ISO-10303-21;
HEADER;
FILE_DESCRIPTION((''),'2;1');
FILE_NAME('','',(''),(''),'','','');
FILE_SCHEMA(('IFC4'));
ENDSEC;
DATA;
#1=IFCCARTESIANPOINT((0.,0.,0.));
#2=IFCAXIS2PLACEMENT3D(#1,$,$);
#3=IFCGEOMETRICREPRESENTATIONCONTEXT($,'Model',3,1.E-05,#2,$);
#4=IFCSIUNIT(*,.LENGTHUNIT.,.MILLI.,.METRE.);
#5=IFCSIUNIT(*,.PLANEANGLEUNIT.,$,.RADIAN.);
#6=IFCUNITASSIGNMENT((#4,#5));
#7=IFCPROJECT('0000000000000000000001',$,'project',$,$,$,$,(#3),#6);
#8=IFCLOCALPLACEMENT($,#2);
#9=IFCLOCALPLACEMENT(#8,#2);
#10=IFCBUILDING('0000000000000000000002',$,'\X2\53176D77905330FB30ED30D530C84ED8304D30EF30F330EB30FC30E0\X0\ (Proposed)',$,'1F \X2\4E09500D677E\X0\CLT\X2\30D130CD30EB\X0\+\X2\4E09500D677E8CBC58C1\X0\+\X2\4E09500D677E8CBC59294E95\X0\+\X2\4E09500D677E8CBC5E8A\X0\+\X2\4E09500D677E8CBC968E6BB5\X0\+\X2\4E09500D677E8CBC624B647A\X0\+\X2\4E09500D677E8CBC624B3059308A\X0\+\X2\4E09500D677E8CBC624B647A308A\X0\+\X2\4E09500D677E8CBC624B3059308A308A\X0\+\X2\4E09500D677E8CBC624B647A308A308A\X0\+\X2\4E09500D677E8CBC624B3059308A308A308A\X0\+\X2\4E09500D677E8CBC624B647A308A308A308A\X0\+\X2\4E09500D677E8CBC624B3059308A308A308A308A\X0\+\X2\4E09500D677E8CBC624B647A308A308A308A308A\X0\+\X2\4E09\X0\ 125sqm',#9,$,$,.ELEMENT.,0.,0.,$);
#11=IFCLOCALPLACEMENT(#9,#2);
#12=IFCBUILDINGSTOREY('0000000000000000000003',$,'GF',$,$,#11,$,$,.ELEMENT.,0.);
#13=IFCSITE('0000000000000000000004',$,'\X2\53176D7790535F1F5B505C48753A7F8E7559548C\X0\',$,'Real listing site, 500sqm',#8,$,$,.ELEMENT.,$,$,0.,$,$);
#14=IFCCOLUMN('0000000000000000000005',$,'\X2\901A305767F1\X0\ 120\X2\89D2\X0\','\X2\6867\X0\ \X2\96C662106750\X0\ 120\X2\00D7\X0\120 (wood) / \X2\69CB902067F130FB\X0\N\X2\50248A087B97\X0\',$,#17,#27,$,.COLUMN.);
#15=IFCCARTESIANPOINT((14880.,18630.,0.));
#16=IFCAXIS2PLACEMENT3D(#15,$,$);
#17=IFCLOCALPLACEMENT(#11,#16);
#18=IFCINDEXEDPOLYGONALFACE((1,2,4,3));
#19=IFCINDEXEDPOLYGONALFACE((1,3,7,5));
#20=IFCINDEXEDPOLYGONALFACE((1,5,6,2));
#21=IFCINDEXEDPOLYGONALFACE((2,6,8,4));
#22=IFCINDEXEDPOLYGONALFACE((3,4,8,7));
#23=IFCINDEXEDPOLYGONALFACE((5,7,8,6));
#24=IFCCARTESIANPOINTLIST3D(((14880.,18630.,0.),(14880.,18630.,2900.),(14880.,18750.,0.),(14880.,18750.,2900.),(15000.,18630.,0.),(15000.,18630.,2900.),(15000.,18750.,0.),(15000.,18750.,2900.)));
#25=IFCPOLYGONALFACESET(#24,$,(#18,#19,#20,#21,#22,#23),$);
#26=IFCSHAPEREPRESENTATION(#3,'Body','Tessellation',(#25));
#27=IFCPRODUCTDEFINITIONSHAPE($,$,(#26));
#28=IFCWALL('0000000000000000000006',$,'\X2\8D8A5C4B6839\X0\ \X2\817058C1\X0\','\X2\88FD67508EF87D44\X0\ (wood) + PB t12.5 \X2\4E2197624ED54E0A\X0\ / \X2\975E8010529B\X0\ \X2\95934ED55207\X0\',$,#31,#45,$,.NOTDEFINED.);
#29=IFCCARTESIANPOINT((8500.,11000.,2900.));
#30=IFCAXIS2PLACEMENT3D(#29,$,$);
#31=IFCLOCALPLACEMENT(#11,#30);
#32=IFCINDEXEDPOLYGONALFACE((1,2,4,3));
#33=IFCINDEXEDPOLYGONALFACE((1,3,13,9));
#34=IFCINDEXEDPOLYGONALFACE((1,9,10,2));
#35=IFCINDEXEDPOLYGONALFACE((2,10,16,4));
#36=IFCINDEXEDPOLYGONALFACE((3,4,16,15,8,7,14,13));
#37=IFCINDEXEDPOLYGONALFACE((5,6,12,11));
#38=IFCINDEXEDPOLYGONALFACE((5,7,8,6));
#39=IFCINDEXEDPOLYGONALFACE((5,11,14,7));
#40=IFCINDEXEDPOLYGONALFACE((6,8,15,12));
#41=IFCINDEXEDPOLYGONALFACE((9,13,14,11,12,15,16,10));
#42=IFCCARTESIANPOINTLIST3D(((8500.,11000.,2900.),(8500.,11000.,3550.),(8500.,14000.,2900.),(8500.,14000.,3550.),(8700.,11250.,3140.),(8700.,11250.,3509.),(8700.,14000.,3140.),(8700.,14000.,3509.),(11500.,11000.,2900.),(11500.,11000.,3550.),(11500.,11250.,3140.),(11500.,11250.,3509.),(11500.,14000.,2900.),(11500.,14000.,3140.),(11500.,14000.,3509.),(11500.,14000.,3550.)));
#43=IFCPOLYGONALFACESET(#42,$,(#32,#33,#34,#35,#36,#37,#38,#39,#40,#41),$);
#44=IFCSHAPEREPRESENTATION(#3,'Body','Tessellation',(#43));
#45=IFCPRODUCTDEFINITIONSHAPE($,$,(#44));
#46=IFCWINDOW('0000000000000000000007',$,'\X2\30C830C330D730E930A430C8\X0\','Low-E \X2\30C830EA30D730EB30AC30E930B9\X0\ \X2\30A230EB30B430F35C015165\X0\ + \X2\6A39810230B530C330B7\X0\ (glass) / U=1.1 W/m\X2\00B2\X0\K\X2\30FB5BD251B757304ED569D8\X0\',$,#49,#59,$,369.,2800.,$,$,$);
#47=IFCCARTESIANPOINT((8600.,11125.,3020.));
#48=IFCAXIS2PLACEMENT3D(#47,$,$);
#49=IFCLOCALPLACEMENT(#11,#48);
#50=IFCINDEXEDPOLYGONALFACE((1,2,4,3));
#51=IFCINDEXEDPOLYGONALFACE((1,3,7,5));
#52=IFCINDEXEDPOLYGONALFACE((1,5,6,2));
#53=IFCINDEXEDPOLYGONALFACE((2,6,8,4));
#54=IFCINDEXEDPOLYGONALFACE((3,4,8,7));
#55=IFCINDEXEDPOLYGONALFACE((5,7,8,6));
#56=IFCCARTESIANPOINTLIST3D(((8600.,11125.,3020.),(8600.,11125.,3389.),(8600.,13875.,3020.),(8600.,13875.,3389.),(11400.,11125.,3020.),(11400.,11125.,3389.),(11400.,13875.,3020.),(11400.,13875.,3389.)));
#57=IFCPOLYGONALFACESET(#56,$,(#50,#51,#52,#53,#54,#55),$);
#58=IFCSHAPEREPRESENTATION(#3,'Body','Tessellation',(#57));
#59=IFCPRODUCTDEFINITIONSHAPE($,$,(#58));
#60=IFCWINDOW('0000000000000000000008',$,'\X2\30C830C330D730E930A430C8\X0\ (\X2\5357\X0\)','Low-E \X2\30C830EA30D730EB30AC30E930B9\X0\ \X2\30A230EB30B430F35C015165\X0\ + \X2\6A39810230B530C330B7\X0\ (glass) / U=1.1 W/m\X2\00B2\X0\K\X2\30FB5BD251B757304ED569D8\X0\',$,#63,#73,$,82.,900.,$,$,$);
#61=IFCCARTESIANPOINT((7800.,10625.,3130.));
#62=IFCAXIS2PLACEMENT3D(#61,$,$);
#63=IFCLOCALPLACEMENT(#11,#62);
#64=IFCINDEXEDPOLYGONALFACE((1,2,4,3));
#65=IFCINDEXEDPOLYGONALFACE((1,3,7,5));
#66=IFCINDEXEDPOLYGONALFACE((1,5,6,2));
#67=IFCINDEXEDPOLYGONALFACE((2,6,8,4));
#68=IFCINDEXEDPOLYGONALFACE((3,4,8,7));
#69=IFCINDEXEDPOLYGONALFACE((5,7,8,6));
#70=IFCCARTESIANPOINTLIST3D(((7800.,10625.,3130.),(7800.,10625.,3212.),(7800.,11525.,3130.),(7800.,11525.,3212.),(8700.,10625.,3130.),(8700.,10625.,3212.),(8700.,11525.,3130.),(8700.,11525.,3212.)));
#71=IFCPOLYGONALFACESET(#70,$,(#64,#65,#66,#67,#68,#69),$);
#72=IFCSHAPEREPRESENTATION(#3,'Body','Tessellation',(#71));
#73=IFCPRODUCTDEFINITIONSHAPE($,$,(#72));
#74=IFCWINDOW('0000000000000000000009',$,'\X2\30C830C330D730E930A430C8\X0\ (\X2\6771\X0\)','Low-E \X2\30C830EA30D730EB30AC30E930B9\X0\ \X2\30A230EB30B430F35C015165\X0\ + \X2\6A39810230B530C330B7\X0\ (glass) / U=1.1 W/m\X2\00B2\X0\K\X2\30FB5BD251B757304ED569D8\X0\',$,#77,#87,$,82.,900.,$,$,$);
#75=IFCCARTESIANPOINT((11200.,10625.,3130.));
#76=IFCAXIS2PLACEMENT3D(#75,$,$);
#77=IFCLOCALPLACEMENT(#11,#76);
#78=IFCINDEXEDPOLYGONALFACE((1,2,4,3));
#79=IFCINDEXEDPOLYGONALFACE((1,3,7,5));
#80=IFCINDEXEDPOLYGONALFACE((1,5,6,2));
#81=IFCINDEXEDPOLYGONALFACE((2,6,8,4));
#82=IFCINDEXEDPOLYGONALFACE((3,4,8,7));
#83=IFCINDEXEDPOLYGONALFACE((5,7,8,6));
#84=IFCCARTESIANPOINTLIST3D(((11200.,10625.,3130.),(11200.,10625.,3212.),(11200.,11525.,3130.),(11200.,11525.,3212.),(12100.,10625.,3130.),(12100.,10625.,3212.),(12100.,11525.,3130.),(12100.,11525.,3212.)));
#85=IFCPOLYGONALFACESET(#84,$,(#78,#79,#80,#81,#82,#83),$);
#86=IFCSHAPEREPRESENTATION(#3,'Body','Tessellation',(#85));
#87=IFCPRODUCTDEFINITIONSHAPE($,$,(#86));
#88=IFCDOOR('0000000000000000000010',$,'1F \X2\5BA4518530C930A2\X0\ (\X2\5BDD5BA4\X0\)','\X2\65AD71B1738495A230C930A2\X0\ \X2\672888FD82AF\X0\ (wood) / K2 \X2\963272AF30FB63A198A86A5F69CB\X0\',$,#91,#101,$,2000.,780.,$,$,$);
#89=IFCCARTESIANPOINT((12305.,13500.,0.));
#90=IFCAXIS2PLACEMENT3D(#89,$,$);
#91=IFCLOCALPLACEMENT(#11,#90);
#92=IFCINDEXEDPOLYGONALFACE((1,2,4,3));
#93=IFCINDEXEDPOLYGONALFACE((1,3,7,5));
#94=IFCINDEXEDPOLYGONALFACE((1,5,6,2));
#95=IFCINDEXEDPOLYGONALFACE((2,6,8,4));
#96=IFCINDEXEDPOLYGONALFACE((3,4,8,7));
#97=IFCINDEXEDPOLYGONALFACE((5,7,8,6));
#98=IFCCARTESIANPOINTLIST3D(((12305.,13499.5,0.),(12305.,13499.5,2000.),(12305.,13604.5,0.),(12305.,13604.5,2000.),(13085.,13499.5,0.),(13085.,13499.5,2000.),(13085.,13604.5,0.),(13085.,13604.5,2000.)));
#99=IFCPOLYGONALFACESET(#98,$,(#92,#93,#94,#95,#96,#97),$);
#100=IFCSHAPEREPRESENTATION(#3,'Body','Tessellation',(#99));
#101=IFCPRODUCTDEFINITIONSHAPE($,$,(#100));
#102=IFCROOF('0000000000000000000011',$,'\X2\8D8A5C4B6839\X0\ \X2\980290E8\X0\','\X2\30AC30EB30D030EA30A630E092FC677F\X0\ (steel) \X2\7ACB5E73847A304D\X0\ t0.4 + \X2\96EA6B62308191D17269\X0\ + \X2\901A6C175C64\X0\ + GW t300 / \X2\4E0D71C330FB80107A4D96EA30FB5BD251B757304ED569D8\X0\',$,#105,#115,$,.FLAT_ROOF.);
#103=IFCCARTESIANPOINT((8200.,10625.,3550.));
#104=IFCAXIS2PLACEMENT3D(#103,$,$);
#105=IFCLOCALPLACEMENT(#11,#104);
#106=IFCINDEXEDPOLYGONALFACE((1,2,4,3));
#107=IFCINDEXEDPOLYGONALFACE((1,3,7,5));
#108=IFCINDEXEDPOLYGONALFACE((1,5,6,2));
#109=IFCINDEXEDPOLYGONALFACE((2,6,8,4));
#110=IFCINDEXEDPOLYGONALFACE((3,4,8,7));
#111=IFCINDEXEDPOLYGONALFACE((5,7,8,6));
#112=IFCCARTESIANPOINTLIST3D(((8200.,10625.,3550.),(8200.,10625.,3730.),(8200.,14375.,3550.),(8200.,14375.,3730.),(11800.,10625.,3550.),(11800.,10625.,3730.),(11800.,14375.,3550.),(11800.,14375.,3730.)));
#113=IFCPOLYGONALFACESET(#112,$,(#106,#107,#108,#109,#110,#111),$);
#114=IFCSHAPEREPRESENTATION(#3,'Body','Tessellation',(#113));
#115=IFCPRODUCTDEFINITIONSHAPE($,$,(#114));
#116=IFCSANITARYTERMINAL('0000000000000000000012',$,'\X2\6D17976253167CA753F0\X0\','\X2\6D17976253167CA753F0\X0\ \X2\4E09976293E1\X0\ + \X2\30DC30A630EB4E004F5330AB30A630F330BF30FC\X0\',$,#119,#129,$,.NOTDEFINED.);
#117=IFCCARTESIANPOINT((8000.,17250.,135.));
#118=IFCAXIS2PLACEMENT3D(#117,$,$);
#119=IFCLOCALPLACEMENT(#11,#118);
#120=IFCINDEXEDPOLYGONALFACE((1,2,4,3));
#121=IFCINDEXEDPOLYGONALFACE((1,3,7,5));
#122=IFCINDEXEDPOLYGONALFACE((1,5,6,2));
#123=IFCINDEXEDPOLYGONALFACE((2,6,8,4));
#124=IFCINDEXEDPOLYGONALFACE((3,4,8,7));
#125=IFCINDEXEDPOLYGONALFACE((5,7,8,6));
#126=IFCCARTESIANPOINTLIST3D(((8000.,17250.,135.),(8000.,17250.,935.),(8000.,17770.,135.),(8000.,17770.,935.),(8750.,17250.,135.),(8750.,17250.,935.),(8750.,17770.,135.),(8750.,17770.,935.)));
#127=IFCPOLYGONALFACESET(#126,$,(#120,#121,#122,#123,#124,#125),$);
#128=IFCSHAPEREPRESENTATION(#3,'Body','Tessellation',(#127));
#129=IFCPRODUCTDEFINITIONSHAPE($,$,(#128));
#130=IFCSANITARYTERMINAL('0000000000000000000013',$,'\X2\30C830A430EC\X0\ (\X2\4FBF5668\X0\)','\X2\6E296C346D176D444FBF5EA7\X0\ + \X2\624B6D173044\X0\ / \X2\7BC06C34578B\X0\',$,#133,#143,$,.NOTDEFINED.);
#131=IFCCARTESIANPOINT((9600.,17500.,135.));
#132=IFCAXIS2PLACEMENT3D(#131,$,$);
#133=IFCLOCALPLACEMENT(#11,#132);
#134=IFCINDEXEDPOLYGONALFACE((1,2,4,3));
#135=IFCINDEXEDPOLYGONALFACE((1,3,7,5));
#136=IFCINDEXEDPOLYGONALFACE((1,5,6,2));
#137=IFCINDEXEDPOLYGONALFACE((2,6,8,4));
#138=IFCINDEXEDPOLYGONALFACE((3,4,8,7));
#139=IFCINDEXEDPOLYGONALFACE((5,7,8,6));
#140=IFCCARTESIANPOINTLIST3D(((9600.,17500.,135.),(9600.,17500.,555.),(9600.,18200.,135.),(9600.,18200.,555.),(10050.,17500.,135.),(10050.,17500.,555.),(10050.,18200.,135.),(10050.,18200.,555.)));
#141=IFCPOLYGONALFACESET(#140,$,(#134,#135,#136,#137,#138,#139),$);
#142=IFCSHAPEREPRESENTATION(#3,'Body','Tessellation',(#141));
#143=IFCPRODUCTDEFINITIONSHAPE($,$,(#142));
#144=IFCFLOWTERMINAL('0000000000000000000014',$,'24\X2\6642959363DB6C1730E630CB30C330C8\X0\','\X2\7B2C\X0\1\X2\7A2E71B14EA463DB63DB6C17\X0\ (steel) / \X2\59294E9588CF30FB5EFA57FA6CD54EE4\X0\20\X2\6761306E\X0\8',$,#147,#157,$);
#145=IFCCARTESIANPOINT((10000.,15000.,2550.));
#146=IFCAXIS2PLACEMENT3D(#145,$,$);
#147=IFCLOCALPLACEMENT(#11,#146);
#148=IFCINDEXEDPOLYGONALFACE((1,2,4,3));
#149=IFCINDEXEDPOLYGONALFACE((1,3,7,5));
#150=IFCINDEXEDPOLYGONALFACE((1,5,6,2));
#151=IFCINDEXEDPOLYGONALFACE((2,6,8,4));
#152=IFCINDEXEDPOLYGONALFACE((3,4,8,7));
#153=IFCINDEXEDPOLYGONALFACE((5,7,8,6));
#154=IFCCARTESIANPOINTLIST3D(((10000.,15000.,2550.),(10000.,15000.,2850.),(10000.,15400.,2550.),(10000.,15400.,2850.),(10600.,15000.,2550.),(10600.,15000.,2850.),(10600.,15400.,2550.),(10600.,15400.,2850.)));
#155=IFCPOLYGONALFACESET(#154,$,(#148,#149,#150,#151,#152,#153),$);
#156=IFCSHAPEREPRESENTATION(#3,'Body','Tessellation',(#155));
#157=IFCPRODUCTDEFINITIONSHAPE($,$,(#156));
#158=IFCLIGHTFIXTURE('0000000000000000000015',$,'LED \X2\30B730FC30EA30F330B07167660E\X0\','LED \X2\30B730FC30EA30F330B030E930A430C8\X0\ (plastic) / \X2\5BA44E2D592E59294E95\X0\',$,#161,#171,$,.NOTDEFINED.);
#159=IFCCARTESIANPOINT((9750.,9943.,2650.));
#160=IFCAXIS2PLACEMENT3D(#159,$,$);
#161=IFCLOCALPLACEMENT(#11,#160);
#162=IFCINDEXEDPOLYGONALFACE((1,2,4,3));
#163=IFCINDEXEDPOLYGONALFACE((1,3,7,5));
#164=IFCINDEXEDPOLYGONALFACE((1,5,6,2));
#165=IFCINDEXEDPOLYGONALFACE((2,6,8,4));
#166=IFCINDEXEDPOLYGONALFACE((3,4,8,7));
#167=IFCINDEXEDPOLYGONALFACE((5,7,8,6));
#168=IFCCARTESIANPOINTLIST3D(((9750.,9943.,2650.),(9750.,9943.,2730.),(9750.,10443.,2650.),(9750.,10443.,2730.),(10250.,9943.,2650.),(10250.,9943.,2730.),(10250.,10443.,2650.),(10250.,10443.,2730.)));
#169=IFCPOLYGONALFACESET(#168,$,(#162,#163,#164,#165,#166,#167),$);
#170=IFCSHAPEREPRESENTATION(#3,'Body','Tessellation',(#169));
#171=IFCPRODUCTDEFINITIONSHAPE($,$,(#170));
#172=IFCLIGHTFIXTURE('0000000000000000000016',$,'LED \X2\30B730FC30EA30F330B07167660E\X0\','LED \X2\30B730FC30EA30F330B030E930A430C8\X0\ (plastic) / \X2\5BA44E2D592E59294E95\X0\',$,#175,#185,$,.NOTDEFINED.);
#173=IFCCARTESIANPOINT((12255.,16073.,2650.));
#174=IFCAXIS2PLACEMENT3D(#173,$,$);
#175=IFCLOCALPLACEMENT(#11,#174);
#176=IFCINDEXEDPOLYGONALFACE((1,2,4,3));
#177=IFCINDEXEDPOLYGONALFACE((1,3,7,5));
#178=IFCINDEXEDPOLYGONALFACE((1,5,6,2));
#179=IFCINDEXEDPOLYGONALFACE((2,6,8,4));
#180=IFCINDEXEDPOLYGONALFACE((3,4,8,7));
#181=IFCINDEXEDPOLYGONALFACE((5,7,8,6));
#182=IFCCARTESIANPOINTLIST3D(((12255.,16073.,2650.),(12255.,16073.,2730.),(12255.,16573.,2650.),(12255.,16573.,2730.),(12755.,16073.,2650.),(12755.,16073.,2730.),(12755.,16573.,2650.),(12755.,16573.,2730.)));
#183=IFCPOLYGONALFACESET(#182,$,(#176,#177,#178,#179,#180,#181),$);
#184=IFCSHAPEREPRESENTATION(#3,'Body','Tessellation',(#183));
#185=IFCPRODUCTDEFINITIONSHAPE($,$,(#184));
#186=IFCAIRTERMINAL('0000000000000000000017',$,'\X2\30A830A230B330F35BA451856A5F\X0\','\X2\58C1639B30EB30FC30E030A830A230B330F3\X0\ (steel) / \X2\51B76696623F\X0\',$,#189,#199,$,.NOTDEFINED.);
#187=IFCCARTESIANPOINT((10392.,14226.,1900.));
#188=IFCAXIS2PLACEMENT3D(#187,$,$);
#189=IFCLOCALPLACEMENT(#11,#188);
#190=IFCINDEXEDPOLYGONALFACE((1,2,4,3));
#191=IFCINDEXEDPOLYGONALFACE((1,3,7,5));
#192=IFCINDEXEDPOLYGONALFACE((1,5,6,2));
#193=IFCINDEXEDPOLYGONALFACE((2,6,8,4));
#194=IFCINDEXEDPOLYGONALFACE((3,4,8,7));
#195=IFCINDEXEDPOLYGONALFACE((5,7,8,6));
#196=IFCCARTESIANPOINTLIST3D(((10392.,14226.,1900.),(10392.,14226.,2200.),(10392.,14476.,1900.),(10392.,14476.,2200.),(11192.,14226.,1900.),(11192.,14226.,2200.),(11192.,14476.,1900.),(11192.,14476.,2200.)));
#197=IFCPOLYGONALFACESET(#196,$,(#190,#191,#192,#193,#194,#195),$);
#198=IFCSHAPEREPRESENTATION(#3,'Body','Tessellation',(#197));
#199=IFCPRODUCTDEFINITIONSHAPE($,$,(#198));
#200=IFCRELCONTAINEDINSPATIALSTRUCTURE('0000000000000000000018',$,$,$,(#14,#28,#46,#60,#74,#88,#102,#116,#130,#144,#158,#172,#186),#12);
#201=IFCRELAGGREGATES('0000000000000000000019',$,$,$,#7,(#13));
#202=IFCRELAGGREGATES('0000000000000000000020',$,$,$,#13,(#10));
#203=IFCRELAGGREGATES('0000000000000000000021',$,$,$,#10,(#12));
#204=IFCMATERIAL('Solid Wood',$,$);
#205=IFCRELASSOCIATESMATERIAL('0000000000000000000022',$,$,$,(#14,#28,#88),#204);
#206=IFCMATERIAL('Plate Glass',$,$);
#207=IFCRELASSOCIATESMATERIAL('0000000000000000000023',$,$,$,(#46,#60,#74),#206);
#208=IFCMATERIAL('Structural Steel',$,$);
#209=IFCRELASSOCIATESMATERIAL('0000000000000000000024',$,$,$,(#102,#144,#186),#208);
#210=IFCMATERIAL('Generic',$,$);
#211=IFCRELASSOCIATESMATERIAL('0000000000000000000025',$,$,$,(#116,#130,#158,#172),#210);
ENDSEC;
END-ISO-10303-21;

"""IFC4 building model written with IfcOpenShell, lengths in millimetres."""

from ifc_helpers import new_model, si_unit, frame, frame_2d, origin, place, context, project, spatial, rectangle, extrude, material, element, fill, save


model = new_model("IFC4")

# Units and contexts
model_context = context("Model", 3, precision=1e-05, world=origin())
ifc_project = project(units=[si_unit("LENGTHUNIT", "METRE", prefix="MILLI"), si_unit("PLANEANGLEUNIT", "RADIAN")], contexts=[model_context])

# Site, building, storey
site_placement = place(None, origin())
site = spatial("IfcSite", under=ifc_project, at=site_placement, Name="北海道弟子屈町美留和", ObjectType="Real listing site, 500sqm", CompositionType="ELEMENT", RefElevation=0.0)
building_placement = place(site_placement, origin())
building = spatial("IfcBuilding", under=site, at=building_placement, Name="北海道・ロフト付きワンルーム (Proposed)", ObjectType="1F 三倍松CLTパネル+三倍松貼壁+三倍松貼天井+三倍松貼床+三倍松貼階段+三倍松貼手摺+三倍松貼手すり+三倍松貼手摺り+三倍松貼手すりり+三倍松貼手摺りり+三倍松貼手すりりり+三倍松貼手摺りりり+三倍松貼手すりりりり+三倍松貼手摺りりりり+三 125sqm", CompositionType="ELEMENT", ElevationOfRefHeight=0.0, ElevationOfTerrain=0.0)
storey_placement = place(building_placement, origin())
storey = spatial("IfcBuildingStorey", under=building, at=storey_placement, Name="GF", CompositionType="ELEMENT", Elevation=0.0)

# Column
ifc_material_1 = material(Name="Solid Wood")
column_1_placement = place(storey_placement, frame((14880.0, 18630.0, 0.0)))
element("IfcColumn", 1, at=column_1_placement, inside=storey, material=ifc_material_1, Name="通し柱 120角", Description="桧 集成材 120×120 (wood) / 構造柱・N値計算", PredefinedType="COLUMN", context=model_context, shape_type="SweptSolid", body=[
    extrude(rectangle(XDim=120.0, YDim=120.0, at=frame_2d((60.0, 60.0))), frame((14880.0, 18630.0, 0.0)), (0.0, 0.0, 1.0), 2900.0),
])

# Wall, openings, windows
wall_1_placement = place(storey_placement, frame((8500.0, 11000.0, 2900.0)))
wall_1 = element("IfcWall", 2, at=wall_1_placement, inside=storey, material=ifc_material_1, Name="越屋根 腰壁", Description="製材軸組 (wood) + PB t12.5 両面仕上 / 非耐力 間仕切", PredefinedType="NOTDEFINED", context=model_context, shape_type="SweptSolid", body=[
    extrude(rectangle(XDim=3000.0, YDim=3000.0, at=frame_2d((1500.0, 1500.0))), frame((8500.0, 11000.0, 2900.0)), (0.0, 0.0, 1.0), 650.0),
])
opening_1_placement = place(storey_placement, frame((8600.0, 11125.0, 3020.0)))
opening_1 = element("IfcOpeningElement", 3, at=opening_1_placement, cuts=wall_1, PredefinedType="NOTDEFINED", context=model_context, shape_type="SweptSolid", body=[
    extrude(rectangle(XDim=2800.0, YDim=2750.0, at=frame_2d((1400.0, 1375.0))), frame((8600.0, 11125.0, 3020.0)), (0.0, 0.0, 1.0), 369.0),
])
opening_2_placement = place(storey_placement, frame((7800.0, 10625.0, 3130.0)))
opening_2 = element("IfcOpeningElement", 4, at=opening_2_placement, cuts=wall_1, PredefinedType="NOTDEFINED", context=model_context, shape_type="SweptSolid", body=[
    extrude(rectangle(XDim=900.0, YDim=900.0, at=frame_2d((450.0, 450.0))), frame((7800.0, 10625.0, 3130.0)), (0.0, 0.0, 1.0), 82.0),
])
opening_3_placement = place(storey_placement, frame((11200.0, 10625.0, 3130.0)))
opening_3 = element("IfcOpeningElement", 5, at=opening_3_placement, cuts=wall_1, PredefinedType="NOTDEFINED", context=model_context, shape_type="SweptSolid", body=[
    extrude(rectangle(XDim=900.0, YDim=900.0, at=frame_2d((450.0, 450.0))), frame((11200.0, 10625.0, 3130.0)), (0.0, 0.0, 1.0), 82.0),
])
ifc_material_2 = material(Name="Plate Glass")
window_1_placement = place(storey_placement, frame((8600.0, 11125.0, 3020.0)))
window_1 = element("IfcWindow", 6, at=window_1_placement, inside=storey, material=ifc_material_2, Name="トップライト", Description="Low-E トリプルガラス アルゴン封入 + 樹脂サッシ (glass) / U=1.1 W/m²K・寒冷地仕様", OverallHeight=369.0, OverallWidth=2800.0, context=model_context, shape_type="SweptSolid", body=[
    extrude(rectangle(XDim=2800.0, YDim=2750.0, at=frame_2d((1400.0, 1375.0))), frame((8600.0, 11125.0, 3020.0)), (0.0, 0.0, 1.0), 369.0),
])
fill(opening_1, window_1)
window_2_placement = place(storey_placement, frame((7800.0, 10625.0, 3130.0)))
window_2 = element("IfcWindow", 7, at=window_2_placement, inside=storey, material=ifc_material_2, Name="トップライト (南)", Description="Low-E トリプルガラス アルゴン封入 + 樹脂サッシ (glass) / U=1.1 W/m²K・寒冷地仕様", OverallHeight=82.0, OverallWidth=900.0, context=model_context, shape_type="SweptSolid", body=[
    extrude(rectangle(XDim=900.0, YDim=900.0, at=frame_2d((450.0, 450.0))), frame((7800.0, 10625.0, 3130.0)), (0.0, 0.0, 1.0), 82.0),
])
fill(opening_2, window_2)
window_3_placement = place(storey_placement, frame((11200.0, 10625.0, 3130.0)))
window_3 = element("IfcWindow", 8, at=window_3_placement, inside=storey, material=ifc_material_2, Name="トップライト (東)", Description="Low-E トリプルガラス アルゴン封入 + 樹脂サッシ (glass) / U=1.1 W/m²K・寒冷地仕様", OverallHeight=82.0, OverallWidth=900.0, context=model_context, shape_type="SweptSolid", body=[
    extrude(rectangle(XDim=900.0, YDim=900.0, at=frame_2d((450.0, 450.0))), frame((11200.0, 10625.0, 3130.0)), (0.0, 0.0, 1.0), 82.0),
])
fill(opening_3, window_3)

# Door
door_placement = place(storey_placement, frame((12305.0, 13500.0, 0.0)))
element("IfcDoor", 9, at=door_placement, inside=storey, material=ifc_material_1, Name="1F 室内ドア (寝室)", Description="断熱玄関ドア 木製芯 (wood) / K2 防犯・採風機構", OverallHeight=2000.0, OverallWidth=780.0, context=model_context, shape_type="SweptSolid", body=[
    extrude(rectangle(XDim=780.0, YDim=105.0, at=frame_2d((390.0, 52.0))), frame((12305.0, 13500.0, 0.0)), (0.0, 0.0, 1.0), 2000.0),
])

# Roof
ifc_material_3 = material(Name="Structural Steel")
roof_placement = place(storey_placement, frame((8200.0, 10625.0, 3550.0)))
element("IfcRoof", 10, at=roof_placement, inside=storey, material=ifc_material_3, Name="越屋根 頂部", Description="ガルバリウム鋼板 (steel) 立平葺き t0.4 + 雪止め金物 + 通気層 + GW t300 / 不燃・耐積雪・寒冷地仕様", PredefinedType="FLAT_ROOF", context=model_context, shape_type="SweptSolid", body=[
    extrude(rectangle(XDim=3600.0, YDim=3750.0, at=frame_2d((1800.0, 1875.0))), frame((8200.0, 10625.0, 3550.0)), (0.0, 0.0, 1.0), 180.0),
])

# Sanitary terminals
ifc_material_4 = material(Name="Generic")
sanitary_terminal_1_placement = place(storey_placement, frame((8000.0, 17250.0, 135.0)))
element("IfcSanitaryTerminal", 11, at=sanitary_terminal_1_placement, inside=storey, material=ifc_material_4, Name="洗面化粧台", Description="洗面化粧台 三面鏡 + ボウル一体カウンター", PredefinedType="NOTDEFINED", context=model_context, shape_type="SweptSolid", body=[
    extrude(rectangle(XDim=750.0, YDim=520.0, at=frame_2d((375.0, 260.0))), frame((8000.0, 17250.0, 135.0)), (0.0, 0.0, 1.0), 800.0),
])
sanitary_terminal_2_placement = place(storey_placement, frame((9600.0, 17500.0, 135.0)))
element("IfcSanitaryTerminal", 12, at=sanitary_terminal_2_placement, inside=storey, material=ifc_material_4, Name="トイレ (便器)", Description="温水洗浄便座 + 手洗い / 節水型", PredefinedType="NOTDEFINED", context=model_context, shape_type="SweptSolid", body=[
    extrude(rectangle(XDim=450.0, YDim=700.0, at=frame_2d((225.0, 350.0))), frame((9600.0, 17500.0, 135.0)), (0.0, 0.0, 1.0), 420.0),
])

# Flow terminal
flow_terminal_placement = place(storey_placement, frame((10000.0, 15000.0, 2550.0)))
element("IfcFlowTerminal", 13, at=flow_terminal_placement, inside=storey, material=ifc_material_3, Name="24時間換気ユニット", Description="第1種熱交換換気 (steel) / 天井裏・建基法令20条の8", context=model_context, shape_type="SweptSolid", body=[
    extrude(rectangle(XDim=600.0, YDim=400.0, at=frame_2d((300.0, 200.0))), frame((10000.0, 15000.0, 2550.0)), (0.0, 0.0, 1.0), 300.0),
])

# Light fixtures
light_fixture_1_placement = place(storey_placement, frame((9750.0, 9943.0, 2650.0)))
element("IfcLightFixture", 14, at=light_fixture_1_placement, inside=storey, material=ifc_material_4, Name="LED シーリング照明", Description="LED シーリングライト (plastic) / 室中央天井", PredefinedType="NOTDEFINED", context=model_context, shape_type="SweptSolid", body=[
    extrude(rectangle(XDim=500.0, YDim=500.0, at=frame_2d((250.0, 250.0))), frame((9750.0, 9943.0, 2650.0)), (0.0, 0.0, 1.0), 80.0),
])
light_fixture_2_placement = place(storey_placement, frame((12255.0, 16073.0, 2650.0)))
element("IfcLightFixture", 15, at=light_fixture_2_placement, inside=storey, material=ifc_material_4, Name="LED シーリング照明", Description="LED シーリングライト (plastic) / 室中央天井", PredefinedType="NOTDEFINED", context=model_context, shape_type="SweptSolid", body=[
    extrude(rectangle(XDim=500.0, YDim=500.0, at=frame_2d((250.0, 250.0))), frame((12255.0, 16073.0, 2650.0)), (0.0, 0.0, 1.0), 80.0),
])

# Air terminal
air_terminal_placement = place(storey_placement, frame((10392.0, 14226.0, 1900.0)))
element("IfcAirTerminal", 16, at=air_terminal_placement, inside=storey, material=ifc_material_3, Name="エアコン室内機", Description="壁掛ルームエアコン (steel) / 冷暖房", PredefinedType="NOTDEFINED", context=model_context, shape_type="SweptSolid", body=[
    extrude(rectangle(XDim=800.0, YDim=250.0, at=frame_2d((400.0, 125.0))), frame((10392.0, 14226.0, 1900.0)), (0.0, 0.0, 1.0), 300.0),
])

save(model, "model.ifc")
